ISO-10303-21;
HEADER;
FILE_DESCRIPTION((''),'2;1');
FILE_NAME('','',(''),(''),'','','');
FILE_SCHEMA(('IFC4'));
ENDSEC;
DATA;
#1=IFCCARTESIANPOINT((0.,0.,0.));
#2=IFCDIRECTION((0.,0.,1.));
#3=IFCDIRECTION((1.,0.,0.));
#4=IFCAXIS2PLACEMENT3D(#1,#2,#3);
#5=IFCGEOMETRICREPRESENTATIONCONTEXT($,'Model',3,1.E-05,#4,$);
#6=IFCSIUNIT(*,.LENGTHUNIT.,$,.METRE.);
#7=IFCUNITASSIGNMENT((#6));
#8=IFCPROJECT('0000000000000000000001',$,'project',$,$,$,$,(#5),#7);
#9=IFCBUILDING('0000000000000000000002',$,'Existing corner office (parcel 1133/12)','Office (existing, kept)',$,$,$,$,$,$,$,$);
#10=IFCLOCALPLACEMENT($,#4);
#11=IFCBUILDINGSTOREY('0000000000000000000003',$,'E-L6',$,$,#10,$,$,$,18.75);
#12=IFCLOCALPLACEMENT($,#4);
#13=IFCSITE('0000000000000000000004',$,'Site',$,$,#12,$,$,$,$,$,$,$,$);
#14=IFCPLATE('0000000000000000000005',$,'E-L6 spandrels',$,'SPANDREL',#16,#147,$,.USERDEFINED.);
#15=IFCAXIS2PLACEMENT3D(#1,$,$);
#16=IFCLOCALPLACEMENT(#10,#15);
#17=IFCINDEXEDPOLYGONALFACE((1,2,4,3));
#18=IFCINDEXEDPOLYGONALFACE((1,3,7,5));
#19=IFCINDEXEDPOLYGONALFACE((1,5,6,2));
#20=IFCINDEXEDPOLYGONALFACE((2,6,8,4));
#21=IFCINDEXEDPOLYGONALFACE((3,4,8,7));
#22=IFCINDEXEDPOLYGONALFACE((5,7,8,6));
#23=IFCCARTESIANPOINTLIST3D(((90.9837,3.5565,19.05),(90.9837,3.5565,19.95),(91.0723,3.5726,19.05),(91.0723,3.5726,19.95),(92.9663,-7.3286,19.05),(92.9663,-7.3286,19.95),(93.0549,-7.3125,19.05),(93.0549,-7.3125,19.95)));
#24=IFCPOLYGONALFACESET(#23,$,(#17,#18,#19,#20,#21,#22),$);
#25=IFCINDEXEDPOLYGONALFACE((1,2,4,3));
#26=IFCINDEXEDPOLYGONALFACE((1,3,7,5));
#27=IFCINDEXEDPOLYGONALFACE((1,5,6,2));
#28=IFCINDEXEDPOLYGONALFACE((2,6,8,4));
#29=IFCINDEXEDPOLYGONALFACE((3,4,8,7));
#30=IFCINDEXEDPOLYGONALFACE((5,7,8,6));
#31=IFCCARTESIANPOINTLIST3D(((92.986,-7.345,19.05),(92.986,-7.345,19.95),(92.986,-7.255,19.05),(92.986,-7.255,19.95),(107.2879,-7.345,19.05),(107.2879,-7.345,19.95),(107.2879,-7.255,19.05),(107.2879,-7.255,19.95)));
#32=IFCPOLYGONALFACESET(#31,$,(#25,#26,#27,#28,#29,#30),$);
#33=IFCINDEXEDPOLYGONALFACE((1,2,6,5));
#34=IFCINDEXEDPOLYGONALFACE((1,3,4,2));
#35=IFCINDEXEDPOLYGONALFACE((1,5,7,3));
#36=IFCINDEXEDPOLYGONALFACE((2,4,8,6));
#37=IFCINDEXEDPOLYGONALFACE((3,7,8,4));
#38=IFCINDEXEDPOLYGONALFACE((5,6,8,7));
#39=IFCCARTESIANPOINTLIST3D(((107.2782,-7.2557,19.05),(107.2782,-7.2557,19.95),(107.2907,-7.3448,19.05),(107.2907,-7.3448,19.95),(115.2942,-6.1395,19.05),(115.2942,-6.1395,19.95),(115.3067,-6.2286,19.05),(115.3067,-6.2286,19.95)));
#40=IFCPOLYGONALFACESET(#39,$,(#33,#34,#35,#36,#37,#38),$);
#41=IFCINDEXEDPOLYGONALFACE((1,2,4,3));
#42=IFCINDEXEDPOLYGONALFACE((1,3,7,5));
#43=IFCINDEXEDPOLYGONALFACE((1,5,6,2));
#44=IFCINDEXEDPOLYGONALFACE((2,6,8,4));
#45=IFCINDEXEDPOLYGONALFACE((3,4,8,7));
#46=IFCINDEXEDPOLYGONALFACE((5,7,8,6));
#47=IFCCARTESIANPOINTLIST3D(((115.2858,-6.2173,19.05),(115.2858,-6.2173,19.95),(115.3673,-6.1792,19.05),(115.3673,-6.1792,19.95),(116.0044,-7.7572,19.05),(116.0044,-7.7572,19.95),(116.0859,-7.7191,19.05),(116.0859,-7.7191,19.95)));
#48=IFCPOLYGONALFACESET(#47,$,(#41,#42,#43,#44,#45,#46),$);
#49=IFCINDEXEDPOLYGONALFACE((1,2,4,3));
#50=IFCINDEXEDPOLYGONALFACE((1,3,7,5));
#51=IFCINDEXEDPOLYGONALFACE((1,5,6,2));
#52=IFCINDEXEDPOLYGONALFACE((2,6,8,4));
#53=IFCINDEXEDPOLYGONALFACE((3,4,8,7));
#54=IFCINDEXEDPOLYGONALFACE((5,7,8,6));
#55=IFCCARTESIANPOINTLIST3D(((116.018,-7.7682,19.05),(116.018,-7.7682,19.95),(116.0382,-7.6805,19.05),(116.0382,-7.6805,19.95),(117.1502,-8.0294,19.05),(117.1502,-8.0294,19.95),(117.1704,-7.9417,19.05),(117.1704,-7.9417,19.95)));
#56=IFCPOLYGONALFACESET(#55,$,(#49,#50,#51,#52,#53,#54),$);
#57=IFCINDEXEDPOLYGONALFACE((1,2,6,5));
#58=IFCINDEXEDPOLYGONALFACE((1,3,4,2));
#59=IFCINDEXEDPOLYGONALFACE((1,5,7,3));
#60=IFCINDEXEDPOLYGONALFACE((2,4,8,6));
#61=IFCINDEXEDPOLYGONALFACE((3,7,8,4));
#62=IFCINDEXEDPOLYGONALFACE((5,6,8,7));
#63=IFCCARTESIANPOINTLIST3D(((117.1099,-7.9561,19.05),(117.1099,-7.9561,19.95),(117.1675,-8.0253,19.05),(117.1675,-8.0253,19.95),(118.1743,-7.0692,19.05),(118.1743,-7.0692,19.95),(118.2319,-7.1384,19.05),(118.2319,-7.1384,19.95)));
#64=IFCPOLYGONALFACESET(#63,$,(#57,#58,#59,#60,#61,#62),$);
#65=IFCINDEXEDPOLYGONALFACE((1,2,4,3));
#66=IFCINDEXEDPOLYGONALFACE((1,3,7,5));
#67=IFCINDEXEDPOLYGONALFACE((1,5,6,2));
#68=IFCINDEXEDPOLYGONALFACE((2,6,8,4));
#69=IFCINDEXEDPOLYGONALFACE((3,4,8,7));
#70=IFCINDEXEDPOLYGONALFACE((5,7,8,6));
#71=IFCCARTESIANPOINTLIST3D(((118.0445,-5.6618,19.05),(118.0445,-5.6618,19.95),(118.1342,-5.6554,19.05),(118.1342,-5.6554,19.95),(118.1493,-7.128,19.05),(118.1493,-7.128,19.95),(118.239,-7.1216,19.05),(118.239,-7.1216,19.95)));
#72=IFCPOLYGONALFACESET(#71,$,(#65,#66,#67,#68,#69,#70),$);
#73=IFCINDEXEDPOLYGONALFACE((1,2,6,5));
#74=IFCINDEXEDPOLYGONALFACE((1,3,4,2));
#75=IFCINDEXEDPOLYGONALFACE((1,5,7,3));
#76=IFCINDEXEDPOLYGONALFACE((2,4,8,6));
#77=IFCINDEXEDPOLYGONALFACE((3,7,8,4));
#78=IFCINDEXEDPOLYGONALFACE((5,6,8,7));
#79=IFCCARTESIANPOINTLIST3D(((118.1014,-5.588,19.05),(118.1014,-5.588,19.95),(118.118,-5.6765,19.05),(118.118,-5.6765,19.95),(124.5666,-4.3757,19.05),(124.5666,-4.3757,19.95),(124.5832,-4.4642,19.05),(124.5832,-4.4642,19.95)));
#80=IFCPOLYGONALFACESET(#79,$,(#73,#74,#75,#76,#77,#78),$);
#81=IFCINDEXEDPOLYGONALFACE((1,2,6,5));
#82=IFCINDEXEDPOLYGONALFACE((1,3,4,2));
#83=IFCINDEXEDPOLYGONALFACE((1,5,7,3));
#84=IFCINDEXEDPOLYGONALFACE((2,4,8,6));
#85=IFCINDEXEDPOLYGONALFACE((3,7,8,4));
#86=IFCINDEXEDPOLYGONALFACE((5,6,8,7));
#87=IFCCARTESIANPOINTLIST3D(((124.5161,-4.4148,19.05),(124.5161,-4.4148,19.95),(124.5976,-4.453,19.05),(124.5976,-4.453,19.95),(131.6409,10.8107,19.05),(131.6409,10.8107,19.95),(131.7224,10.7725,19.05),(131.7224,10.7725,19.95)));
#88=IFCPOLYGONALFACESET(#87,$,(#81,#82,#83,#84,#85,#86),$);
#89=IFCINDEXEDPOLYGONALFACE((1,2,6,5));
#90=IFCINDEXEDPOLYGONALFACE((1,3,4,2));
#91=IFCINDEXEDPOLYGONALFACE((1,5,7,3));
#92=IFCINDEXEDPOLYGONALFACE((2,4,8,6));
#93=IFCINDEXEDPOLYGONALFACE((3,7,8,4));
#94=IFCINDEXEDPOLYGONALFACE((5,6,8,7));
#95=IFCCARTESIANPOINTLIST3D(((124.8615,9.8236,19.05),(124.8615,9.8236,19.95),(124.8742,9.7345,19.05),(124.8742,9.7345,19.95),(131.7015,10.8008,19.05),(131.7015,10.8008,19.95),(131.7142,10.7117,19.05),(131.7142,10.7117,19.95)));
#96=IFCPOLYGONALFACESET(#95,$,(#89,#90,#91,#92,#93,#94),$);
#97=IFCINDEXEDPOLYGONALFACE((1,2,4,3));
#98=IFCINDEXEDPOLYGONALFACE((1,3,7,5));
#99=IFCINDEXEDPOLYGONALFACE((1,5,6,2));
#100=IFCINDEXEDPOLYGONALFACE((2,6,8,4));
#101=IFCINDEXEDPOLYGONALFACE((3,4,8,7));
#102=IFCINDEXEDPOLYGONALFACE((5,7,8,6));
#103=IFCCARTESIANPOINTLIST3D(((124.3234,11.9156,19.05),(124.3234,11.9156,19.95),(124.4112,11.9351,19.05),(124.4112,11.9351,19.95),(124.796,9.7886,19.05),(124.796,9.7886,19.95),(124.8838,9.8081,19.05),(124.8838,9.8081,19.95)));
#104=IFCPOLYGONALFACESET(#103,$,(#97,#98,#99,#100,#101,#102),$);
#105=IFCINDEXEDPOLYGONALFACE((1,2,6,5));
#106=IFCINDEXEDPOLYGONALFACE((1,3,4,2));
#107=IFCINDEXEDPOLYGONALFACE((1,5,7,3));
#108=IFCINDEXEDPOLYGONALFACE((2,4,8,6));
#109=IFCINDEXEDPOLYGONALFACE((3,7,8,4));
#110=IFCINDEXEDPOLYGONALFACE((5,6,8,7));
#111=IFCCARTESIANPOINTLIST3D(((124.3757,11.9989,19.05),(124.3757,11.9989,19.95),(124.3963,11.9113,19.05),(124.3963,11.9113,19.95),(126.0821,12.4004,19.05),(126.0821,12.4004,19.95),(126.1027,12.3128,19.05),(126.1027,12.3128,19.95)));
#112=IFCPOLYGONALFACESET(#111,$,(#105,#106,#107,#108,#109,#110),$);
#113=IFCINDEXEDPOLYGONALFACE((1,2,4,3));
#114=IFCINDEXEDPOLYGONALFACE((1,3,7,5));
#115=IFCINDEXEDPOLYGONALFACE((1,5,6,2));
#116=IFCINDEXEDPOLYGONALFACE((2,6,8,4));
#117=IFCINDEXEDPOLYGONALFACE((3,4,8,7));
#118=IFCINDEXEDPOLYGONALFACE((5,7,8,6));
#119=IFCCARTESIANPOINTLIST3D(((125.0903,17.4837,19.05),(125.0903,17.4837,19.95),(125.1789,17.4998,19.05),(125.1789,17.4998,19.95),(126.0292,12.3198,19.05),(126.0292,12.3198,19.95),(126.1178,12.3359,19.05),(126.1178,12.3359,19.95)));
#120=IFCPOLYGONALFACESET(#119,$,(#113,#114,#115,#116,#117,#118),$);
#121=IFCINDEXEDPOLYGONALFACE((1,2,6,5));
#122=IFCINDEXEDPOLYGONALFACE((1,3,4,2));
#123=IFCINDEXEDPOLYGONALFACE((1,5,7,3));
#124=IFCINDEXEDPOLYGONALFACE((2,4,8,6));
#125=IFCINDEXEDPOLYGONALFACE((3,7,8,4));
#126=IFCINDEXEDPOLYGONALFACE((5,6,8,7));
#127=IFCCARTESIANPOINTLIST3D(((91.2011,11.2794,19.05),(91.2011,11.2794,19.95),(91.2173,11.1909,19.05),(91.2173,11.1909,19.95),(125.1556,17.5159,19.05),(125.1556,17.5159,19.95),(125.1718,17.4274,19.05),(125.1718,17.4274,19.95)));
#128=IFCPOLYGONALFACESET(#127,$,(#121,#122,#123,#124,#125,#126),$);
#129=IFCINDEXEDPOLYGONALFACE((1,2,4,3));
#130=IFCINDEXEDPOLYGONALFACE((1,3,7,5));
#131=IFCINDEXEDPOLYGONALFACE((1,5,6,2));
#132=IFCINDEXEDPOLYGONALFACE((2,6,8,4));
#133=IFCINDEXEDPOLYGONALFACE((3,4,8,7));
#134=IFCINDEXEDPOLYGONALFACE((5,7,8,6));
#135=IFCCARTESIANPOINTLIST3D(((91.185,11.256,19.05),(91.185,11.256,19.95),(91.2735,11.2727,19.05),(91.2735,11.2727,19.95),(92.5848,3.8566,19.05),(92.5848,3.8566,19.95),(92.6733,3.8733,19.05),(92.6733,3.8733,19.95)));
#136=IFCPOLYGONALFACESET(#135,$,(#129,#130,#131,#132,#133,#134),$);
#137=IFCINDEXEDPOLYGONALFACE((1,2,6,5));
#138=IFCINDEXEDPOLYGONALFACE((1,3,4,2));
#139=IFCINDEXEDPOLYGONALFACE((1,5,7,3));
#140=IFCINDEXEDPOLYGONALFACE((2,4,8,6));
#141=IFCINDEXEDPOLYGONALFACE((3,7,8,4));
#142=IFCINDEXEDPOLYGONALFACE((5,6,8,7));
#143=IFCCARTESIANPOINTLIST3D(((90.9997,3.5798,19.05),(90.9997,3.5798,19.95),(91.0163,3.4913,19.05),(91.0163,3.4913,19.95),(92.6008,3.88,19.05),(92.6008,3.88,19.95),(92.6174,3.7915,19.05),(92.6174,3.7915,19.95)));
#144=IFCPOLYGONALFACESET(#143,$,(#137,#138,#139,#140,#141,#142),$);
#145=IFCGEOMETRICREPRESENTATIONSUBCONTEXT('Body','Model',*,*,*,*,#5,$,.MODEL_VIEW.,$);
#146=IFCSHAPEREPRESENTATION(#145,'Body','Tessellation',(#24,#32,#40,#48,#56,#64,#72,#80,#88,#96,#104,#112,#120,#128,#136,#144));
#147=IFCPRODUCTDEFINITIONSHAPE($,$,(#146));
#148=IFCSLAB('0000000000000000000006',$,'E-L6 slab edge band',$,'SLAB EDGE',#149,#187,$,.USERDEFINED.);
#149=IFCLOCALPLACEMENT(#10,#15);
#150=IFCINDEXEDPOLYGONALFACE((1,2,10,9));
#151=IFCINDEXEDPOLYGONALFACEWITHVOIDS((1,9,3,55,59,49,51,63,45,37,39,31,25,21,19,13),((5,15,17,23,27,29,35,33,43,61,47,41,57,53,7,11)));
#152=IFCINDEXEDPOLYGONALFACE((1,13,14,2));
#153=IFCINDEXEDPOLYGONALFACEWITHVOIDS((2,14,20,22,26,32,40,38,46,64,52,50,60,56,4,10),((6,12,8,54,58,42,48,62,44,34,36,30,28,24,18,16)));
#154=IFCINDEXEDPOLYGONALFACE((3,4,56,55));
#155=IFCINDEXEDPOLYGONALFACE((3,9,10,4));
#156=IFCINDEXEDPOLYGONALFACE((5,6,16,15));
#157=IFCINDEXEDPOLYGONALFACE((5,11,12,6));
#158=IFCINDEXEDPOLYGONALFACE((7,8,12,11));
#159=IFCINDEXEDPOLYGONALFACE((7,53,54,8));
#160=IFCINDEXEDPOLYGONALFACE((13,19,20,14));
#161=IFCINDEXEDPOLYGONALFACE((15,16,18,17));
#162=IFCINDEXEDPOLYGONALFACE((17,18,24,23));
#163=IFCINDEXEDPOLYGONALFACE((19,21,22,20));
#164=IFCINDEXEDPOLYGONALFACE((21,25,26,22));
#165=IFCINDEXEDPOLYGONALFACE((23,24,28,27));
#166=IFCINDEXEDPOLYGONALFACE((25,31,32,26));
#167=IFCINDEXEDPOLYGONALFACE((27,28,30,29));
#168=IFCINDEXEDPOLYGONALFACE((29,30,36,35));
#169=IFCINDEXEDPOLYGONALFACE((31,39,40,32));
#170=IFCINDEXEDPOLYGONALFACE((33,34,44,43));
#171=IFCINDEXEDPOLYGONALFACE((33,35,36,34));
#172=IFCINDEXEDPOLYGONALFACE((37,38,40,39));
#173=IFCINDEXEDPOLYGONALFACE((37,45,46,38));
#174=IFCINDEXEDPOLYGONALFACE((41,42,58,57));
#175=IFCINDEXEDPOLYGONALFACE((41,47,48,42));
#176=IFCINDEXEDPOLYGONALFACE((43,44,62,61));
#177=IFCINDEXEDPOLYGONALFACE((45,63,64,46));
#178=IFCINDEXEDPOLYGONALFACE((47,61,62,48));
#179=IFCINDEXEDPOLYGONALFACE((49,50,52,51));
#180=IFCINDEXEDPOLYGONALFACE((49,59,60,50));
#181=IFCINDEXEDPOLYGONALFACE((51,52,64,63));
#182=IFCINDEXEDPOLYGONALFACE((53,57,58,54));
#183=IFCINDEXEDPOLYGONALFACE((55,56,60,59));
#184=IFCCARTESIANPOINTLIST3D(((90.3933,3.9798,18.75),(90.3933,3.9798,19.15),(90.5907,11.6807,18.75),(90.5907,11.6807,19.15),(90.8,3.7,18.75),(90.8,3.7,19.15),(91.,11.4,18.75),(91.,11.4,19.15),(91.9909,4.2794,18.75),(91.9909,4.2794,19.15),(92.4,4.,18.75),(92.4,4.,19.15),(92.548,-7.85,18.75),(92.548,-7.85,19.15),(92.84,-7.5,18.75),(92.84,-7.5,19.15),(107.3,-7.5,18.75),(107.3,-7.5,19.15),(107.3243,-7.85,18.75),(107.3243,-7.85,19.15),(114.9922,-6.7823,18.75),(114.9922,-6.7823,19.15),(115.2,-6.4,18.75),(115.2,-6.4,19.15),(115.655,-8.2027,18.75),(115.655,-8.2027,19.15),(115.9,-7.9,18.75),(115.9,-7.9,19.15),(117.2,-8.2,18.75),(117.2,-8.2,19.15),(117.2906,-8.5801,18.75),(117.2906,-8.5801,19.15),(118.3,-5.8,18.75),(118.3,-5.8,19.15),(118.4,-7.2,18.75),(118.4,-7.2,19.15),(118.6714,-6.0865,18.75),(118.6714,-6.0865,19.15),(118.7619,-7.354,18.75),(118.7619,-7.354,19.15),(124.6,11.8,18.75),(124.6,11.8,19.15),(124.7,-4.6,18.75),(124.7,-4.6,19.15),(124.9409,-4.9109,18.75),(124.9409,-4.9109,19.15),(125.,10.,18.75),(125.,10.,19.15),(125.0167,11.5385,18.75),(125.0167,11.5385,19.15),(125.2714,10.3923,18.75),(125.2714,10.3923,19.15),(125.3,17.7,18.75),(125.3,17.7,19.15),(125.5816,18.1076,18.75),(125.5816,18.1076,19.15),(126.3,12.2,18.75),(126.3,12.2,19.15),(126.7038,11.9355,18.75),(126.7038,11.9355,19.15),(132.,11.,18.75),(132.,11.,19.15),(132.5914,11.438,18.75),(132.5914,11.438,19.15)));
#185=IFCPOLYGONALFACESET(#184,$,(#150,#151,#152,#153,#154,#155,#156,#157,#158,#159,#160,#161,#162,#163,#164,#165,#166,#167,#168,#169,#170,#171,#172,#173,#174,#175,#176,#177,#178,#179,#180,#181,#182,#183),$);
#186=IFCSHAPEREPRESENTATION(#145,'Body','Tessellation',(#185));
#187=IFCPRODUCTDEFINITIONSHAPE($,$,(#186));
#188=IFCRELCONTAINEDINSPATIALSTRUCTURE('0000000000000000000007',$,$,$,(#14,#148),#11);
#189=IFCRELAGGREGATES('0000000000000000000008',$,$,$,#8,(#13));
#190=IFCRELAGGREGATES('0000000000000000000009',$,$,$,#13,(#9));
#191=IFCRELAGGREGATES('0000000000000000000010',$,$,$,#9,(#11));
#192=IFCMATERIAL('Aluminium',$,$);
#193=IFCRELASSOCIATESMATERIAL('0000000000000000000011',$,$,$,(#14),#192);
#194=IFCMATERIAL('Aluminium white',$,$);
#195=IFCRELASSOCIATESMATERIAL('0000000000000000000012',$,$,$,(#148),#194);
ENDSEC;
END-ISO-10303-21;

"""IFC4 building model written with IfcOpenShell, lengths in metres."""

from ifc_helpers import new_model, si_unit, frame, origin_with_axes, place, context, subcontext, project, spatial, polyline, outline, extrude, material, element, save


model = new_model("IFC4")

# Units and contexts
model_context = context("Model", 3, precision=1e-05, world=origin_with_axes())
body_context = subcontext(model_context, "Body", "Model", "MODEL_VIEW")
ifc_project = project(units=[si_unit("LENGTHUNIT", "METRE")], contexts=[model_context])

# Site, building, storey
site_placement = place(None, origin_with_axes())
site = spatial("IfcSite", under=ifc_project, at=site_placement, Name="Site")
building = spatial("IfcBuilding", under=site, Name="Existing corner office (parcel 1133/12)", Description="Office (existing, kept)")
storey_placement = place(None, origin_with_axes())
storey = spatial("IfcBuildingStorey", under=building, at=storey_placement, Name="E-L6", Elevation=18.75)

# Shared definitions
ifc_material_1 = material(Name="Aluminium")
ifc_material_2 = material(Name="Aluminium white")

# Plate
plate_placement = place(storey_placement, origin_with_axes())
element("IfcPlate", 1, at=plate_placement, inside=storey, material=ifc_material_1, Name="E-L6 spandrels", ObjectType="SPANDREL", PredefinedType="USERDEFINED", context=body_context, shape_type="SweptSolid", body=[
    extrude(outline(polyline([(90.9837, 3.5565), (92.9663, -7.3286), (93.0549, -7.3125), (91.0723, 3.5726), (90.9837, 3.5565)])), frame((0.0, 0.0, 19.05), z_axis=(0.0, 0.0, 1.0), x_axis=(1.0, 0.0, 0.0)), (0.0, 0.0, 1.0), 0.9),
    extrude(outline(polyline([(92.986, -7.345), (107.2879, -7.345), (107.2879, -7.255), (92.986, -7.255), (92.986, -7.345)])), frame((0.0, 0.0, 19.05), z_axis=(0.0, 0.0, 1.0), x_axis=(1.0, 0.0, 0.0)), (0.0, 0.0, 1.0), 0.9),
    extrude(outline(polyline([(107.2907, -7.3448), (115.3067, -6.2286), (115.2942, -6.1395), (107.2782, -7.2557), (107.2907, -7.3448)])), frame((0.0, 0.0, 19.05), z_axis=(0.0, 0.0, 1.0), x_axis=(1.0, 0.0, 0.0)), (0.0, 0.0, 1.0), 0.9),
    extrude(outline(polyline([(115.2858, -6.2173), (116.0044, -7.7572), (116.0859, -7.7191), (115.3673, -6.1792), (115.2858, -6.2173)])), frame((0.0, 0.0, 19.05), z_axis=(0.0, 0.0, 1.0), x_axis=(1.0, 0.0, 0.0)), (0.0, 0.0, 1.0), 0.9),
    extrude(outline(polyline([(116.018, -7.7682), (117.1502, -8.0294), (117.1704, -7.9417), (116.0382, -7.6805), (116.018, -7.7682)])), frame((0.0, 0.0, 19.05), z_axis=(0.0, 0.0, 1.0), x_axis=(1.0, 0.0, 0.0)), (0.0, 0.0, 1.0), 0.9),
    extrude(outline(polyline([(117.1675, -8.0253), (118.2319, -7.1384), (118.1743, -7.0692), (117.1099, -7.9561), (117.1675, -8.0253)])), frame((0.0, 0.0, 19.05), z_axis=(0.0, 0.0, 1.0), x_axis=(1.0, 0.0, 0.0)), (0.0, 0.0, 1.0), 0.9),
    extrude(outline(polyline([(118.239, -7.1216), (118.1342, -5.6554), (118.0445, -5.6618), (118.1493, -7.128), (118.239, -7.1216)])), frame((0.0, 0.0, 19.05), z_axis=(0.0, 0.0, 1.0), x_axis=(1.0, 0.0, 0.0)), (0.0, 0.0, 1.0), 0.9),
    extrude(outline(polyline([(118.118, -5.6765), (124.5832, -4.4642), (124.5666, -4.3757), (118.1014, -5.588), (118.118, -5.6765)])), frame((0.0, 0.0, 19.05), z_axis=(0.0, 0.0, 1.0), x_axis=(1.0, 0.0, 0.0)), (0.0, 0.0, 1.0), 0.9),
    extrude(outline(polyline([(124.5976, -4.453), (131.7224, 10.7725), (131.6409, 10.8107), (124.5161, -4.4148), (124.5976, -4.453)])), frame((0.0, 0.0, 19.05), z_axis=(0.0, 0.0, 1.0), x_axis=(1.0, 0.0, 0.0)), (0.0, 0.0, 1.0), 0.9),
    extrude(outline(polyline([(131.7015, 10.8008), (124.8615, 9.8236), (124.8742, 9.7345), (131.7142, 10.7117), (131.7015, 10.8008)])), frame((0.0, 0.0, 19.05), z_axis=(0.0, 0.0, 1.0), x_axis=(1.0, 0.0, 0.0)), (0.0, 0.0, 1.0), 0.9),
    extrude(outline(polyline([(124.8838, 9.8081), (124.4112, 11.9351), (124.3234, 11.9156), (124.796, 9.7886), (124.8838, 9.8081)])), frame((0.0, 0.0, 19.05), z_axis=(0.0, 0.0, 1.0), x_axis=(1.0, 0.0, 0.0)), (0.0, 0.0, 1.0), 0.9),
    extrude(outline(polyline([(124.3963, 11.9113), (126.1027, 12.3128), (126.0821, 12.4004), (124.3757, 11.9989), (124.3963, 11.9113)])), frame((0.0, 0.0, 19.05), z_axis=(0.0, 0.0, 1.0), x_axis=(1.0, 0.0, 0.0)), (0.0, 0.0, 1.0), 0.9),
    extrude(outline(polyline([(126.1178, 12.3359), (125.1789, 17.4998), (125.0903, 17.4837), (126.0292, 12.3198), (126.1178, 12.3359)])), frame((0.0, 0.0, 19.05), z_axis=(0.0, 0.0, 1.0), x_axis=(1.0, 0.0, 0.0)), (0.0, 0.0, 1.0), 0.9),
    extrude(outline(polyline([(125.1556, 17.5159), (91.2011, 11.2794), (91.2173, 11.1909), (125.1718, 17.4274), (125.1556, 17.5159)])), frame((0.0, 0.0, 19.05), z_axis=(0.0, 0.0, 1.0), x_axis=(1.0, 0.0, 0.0)), (0.0, 0.0, 1.0), 0.9),
    extrude(outline(polyline([(91.185, 11.256), (92.5848, 3.8566), (92.6733, 3.8733), (91.2735, 11.2727), (91.185, 11.256)])), frame((0.0, 0.0, 19.05), z_axis=(0.0, 0.0, 1.0), x_axis=(1.0, 0.0, 0.0)), (0.0, 0.0, 1.0), 0.9),
    extrude(outline(polyline([(92.6008, 3.88), (90.9997, 3.5798), (91.0163, 3.4913), (92.6174, 3.7915), (92.6008, 3.88)])), frame((0.0, 0.0, 19.05), z_axis=(0.0, 0.0, 1.0), x_axis=(1.0, 0.0, 0.0)), (0.0, 0.0, 1.0), 0.9),
])

# Slab
slab_1_placement = place(storey_placement, origin_with_axes())
element("IfcSlab", 2, at=slab_1_placement, inside=storey, material=ifc_material_2, Name="E-L6 slab edge band", ObjectType="SLAB EDGE", PredefinedType="USERDEFINED", context=body_context, shape_type="SweptSolid", body=[
    extrude(outline(polyline([(90.3933, 3.9798), (92.548, -7.85), (107.3243, -7.85), (114.9922, -6.7823), (115.655, -8.2027), (117.2906, -8.5801), (118.7619, -7.354), (118.6714, -6.0865), (124.9409, -4.9109), (132.5914, 11.438), (125.2714, 10.3923), (125.0167, 11.5385), (126.7038, 11.9355), (125.5816, 18.1076), (90.5907, 11.6807), (91.9909, 4.2794), (90.3933, 3.9798)]), holes=[polyline([(90.8, 3.7), (92.84, -7.5), (107.3, -7.5), (115.2, -6.4), (115.9, -7.9), (117.2, -8.2), (118.4, -7.2), (118.3, -5.8), (124.7, -4.6), (132.0, 11.0), (125.0, 10.0), (124.6, 11.8), (126.3, 12.2), (125.3, 17.7), (91.0, 11.4), (92.4, 4.0), (90.8, 3.7)])]), frame((0.0, 0.0, 18.75), z_axis=(0.0, 0.0, 1.0), x_axis=(1.0, 0.0, 0.0)), (0.0, 0.0, 1.0), 0.4),
])

save(model, "model.ifc")
